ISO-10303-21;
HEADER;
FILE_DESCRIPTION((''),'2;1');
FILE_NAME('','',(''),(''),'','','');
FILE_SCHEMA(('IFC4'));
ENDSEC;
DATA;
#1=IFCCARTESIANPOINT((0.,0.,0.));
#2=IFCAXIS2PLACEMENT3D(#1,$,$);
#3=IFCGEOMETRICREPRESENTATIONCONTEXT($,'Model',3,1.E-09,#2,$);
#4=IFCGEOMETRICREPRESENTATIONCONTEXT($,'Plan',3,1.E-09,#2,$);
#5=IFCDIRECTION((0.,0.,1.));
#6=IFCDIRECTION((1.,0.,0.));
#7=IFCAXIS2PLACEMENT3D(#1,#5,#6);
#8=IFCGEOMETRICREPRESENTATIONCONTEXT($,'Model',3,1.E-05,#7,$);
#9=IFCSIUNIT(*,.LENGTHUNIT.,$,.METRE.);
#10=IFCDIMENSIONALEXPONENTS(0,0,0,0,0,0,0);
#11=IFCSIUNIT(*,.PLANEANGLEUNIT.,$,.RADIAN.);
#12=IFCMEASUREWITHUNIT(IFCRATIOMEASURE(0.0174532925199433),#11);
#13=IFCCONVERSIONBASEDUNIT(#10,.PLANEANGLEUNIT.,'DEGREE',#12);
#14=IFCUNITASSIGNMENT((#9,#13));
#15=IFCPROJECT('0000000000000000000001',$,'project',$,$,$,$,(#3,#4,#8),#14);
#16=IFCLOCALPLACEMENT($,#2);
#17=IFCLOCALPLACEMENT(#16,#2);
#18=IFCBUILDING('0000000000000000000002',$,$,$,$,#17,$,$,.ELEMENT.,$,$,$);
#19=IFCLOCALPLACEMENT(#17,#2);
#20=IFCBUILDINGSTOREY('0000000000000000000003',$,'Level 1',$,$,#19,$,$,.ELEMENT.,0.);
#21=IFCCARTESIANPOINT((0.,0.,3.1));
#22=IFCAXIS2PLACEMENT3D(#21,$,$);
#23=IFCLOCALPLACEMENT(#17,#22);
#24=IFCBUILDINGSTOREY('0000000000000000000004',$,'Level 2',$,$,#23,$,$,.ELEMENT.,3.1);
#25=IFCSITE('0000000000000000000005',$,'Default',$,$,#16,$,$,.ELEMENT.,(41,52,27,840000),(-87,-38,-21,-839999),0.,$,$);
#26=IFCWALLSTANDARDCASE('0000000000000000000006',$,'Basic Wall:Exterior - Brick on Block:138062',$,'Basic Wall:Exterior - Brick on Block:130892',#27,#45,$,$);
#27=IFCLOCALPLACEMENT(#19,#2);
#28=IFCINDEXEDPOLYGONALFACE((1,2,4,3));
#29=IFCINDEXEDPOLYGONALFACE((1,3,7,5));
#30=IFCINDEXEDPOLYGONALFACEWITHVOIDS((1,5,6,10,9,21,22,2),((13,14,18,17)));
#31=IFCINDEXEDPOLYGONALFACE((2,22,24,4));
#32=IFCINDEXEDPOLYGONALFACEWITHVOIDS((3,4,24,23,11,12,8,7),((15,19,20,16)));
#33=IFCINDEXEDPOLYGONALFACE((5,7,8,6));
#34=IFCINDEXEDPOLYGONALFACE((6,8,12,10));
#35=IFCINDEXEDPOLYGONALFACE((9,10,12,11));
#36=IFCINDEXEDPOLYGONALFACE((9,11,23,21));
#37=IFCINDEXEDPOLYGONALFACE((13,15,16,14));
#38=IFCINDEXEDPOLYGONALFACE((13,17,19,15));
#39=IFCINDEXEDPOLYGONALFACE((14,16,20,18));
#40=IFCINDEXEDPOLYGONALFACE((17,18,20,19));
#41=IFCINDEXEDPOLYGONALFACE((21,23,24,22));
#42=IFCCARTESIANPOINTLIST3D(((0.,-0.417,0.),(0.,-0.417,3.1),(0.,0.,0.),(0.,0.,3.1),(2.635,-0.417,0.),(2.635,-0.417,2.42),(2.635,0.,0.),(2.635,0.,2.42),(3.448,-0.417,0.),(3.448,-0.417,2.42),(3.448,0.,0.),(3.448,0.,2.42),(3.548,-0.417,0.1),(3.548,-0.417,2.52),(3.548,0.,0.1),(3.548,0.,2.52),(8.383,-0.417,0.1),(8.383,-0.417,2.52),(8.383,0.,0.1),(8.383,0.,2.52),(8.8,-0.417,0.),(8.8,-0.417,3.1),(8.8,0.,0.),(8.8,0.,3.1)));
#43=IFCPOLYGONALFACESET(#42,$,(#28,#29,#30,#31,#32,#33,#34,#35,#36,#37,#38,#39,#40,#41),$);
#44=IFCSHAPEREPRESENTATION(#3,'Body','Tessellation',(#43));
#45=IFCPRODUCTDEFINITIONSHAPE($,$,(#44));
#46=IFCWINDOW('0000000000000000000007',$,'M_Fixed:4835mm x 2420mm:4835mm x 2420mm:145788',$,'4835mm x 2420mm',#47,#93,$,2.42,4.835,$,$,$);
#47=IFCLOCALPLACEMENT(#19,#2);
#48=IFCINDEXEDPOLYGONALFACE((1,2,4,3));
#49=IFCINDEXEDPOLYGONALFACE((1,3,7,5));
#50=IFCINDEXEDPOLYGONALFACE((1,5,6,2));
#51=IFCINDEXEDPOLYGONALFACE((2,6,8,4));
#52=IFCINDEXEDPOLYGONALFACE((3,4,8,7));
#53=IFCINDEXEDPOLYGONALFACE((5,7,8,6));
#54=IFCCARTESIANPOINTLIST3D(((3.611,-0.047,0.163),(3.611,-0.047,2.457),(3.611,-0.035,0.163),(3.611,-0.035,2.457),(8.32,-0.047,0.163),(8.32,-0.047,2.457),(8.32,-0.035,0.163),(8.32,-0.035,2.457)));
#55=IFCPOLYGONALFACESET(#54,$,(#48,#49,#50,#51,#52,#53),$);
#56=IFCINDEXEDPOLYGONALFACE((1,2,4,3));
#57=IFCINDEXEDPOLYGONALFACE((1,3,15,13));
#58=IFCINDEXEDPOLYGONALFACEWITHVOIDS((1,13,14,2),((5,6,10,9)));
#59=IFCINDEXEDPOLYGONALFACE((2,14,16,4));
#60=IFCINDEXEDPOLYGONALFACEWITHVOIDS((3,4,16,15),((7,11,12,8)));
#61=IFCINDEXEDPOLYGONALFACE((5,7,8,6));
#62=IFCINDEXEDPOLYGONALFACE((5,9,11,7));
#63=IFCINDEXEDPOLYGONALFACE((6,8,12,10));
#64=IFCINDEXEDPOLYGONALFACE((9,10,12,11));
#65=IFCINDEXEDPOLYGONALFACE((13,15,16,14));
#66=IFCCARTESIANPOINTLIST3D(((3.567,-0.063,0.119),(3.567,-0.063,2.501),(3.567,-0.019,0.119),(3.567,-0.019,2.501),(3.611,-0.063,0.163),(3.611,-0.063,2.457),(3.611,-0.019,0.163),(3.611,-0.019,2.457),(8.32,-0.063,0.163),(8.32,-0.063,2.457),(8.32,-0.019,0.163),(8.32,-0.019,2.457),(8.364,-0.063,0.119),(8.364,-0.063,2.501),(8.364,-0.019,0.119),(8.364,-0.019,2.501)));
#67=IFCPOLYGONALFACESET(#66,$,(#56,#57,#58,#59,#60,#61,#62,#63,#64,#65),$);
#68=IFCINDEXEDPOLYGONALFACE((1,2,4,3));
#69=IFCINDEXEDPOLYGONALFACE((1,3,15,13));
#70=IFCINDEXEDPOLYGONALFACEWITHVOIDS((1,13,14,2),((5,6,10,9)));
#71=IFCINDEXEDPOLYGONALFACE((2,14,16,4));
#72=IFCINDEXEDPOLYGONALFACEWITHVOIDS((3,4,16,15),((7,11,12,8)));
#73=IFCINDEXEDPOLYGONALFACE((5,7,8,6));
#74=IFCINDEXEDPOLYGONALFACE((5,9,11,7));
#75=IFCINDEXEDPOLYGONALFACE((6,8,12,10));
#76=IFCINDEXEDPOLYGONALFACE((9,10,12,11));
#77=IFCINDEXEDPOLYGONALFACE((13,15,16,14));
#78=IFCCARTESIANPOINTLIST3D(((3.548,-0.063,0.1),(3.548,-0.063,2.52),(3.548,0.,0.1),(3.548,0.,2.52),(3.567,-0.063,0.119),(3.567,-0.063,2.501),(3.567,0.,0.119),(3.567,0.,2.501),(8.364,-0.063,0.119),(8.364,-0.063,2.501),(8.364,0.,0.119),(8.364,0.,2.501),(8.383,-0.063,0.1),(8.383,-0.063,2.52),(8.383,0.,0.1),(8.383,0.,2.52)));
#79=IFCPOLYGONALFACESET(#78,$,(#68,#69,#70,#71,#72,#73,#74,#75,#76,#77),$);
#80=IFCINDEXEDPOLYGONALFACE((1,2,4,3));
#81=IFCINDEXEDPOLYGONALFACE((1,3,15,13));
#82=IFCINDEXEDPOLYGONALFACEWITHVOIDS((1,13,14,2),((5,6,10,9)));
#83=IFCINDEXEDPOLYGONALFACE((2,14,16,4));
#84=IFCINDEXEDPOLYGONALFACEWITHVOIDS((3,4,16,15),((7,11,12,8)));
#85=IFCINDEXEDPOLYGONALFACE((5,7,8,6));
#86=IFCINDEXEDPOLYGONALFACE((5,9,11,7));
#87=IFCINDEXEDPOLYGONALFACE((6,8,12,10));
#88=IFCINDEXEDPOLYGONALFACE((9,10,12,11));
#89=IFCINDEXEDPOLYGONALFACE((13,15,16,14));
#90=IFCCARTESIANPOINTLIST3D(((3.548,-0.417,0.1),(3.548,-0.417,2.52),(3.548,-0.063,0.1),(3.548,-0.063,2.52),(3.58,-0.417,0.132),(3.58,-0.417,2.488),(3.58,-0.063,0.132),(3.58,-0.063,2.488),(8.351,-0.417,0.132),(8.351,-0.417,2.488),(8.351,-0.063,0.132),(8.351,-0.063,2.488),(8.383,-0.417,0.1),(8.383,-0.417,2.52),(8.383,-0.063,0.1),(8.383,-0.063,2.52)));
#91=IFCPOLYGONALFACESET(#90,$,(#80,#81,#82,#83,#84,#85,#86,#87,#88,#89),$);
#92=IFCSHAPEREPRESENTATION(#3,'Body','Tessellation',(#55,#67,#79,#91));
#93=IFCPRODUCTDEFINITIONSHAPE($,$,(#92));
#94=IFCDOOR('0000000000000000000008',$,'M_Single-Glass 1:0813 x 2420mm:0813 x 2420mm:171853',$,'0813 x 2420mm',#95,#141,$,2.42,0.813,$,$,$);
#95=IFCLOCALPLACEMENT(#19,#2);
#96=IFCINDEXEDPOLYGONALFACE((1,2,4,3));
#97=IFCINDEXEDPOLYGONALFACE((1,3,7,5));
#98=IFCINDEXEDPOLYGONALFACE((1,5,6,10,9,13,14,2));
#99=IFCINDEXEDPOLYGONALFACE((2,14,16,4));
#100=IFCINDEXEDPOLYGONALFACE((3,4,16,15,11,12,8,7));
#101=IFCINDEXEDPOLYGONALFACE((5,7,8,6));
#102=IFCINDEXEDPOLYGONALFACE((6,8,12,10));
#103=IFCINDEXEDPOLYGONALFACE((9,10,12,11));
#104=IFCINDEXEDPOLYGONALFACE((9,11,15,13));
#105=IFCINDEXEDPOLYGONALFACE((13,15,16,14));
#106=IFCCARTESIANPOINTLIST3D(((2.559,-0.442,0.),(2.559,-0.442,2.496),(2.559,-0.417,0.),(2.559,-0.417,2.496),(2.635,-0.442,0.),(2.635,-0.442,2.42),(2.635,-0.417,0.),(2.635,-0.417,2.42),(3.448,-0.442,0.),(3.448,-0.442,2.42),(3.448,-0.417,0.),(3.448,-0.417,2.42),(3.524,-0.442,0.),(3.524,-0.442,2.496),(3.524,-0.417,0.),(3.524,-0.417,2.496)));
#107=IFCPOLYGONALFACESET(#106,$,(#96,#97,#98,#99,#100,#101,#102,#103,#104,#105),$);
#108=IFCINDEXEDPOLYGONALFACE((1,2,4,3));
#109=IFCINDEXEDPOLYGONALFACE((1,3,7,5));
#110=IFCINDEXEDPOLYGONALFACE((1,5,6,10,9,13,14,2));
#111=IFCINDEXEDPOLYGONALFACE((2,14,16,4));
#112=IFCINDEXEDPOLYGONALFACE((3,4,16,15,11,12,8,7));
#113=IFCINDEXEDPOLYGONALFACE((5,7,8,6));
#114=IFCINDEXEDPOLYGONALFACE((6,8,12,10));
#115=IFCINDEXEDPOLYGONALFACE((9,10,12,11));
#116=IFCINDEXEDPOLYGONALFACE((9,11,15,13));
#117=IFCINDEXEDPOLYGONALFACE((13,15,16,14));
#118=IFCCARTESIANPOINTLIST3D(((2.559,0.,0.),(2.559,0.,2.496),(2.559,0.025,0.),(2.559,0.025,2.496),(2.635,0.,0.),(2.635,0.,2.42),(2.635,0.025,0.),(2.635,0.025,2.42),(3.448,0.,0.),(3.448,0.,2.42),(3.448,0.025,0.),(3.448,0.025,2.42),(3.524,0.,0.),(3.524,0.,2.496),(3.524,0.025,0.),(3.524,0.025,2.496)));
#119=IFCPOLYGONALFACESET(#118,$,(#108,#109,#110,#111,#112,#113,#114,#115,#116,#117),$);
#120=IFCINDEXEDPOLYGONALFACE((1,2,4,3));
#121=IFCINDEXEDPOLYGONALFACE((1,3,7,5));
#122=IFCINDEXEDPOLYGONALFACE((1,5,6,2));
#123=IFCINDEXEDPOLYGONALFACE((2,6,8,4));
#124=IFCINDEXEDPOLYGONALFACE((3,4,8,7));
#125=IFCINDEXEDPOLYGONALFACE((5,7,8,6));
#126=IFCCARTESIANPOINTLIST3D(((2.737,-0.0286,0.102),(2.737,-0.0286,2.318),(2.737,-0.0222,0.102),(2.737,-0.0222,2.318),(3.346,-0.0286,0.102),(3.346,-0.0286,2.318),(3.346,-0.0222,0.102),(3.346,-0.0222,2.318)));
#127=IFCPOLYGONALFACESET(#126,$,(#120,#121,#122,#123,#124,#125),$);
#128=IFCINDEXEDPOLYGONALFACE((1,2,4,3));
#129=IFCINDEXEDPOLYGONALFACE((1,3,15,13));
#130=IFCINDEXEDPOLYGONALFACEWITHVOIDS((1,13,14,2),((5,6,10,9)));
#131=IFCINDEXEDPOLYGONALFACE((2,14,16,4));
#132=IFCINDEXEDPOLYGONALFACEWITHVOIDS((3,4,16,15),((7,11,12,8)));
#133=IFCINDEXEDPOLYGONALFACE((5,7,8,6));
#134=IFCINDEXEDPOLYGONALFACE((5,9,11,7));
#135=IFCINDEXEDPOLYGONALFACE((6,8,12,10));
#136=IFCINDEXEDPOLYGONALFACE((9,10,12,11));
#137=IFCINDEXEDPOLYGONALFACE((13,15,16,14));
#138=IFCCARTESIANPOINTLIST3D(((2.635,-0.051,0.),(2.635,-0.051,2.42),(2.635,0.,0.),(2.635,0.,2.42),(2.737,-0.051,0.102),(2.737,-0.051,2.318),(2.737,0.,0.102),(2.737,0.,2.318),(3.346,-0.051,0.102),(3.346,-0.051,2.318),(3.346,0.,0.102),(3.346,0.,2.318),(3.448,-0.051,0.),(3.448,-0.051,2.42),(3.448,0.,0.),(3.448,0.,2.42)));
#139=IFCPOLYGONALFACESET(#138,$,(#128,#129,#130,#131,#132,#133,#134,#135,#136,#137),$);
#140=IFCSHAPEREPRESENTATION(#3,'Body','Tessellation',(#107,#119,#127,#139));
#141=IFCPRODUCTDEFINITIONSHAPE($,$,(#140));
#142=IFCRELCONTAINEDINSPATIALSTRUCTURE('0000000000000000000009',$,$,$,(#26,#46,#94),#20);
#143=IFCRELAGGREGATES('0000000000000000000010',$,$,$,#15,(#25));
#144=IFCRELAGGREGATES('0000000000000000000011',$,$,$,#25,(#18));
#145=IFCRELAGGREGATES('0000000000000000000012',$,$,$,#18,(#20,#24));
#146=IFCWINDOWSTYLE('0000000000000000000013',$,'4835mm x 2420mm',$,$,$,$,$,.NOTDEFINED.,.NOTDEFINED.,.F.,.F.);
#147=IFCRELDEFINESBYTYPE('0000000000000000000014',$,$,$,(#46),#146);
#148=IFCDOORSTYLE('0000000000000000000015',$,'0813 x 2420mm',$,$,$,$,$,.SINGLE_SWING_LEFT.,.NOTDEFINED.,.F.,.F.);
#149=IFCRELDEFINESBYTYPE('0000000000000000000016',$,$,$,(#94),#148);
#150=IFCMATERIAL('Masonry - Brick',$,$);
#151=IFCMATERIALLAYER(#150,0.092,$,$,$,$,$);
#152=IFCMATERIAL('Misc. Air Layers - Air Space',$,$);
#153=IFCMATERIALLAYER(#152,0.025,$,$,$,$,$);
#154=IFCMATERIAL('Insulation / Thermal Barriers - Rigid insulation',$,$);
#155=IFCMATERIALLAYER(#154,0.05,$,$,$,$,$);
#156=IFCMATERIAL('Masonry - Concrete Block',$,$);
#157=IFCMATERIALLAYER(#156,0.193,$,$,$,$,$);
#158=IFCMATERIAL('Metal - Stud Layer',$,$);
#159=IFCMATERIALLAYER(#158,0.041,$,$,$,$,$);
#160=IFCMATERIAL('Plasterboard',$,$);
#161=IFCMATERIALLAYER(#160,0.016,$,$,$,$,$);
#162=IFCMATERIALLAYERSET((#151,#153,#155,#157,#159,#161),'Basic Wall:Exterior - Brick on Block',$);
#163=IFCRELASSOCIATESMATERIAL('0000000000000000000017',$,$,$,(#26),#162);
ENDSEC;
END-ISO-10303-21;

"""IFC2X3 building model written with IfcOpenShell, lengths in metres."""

from ifc_helpers import new_model, entity, si_unit, converted_unit, frame, frame_2d, origin, origin_with_axes, origin_2d_with_axis, place, context, project, spatial, polyline, rectangle, outline, extrude, source, transform, mapped, material, layer, layer_set, layer_usage, type_object, type_shapes, element, fill, save


model = new_model("IFC2X3")

# Units and contexts
model_context_1 = context("Model", 3, precision=1e-09, world=origin())
plan_context = context("Plan", 3, precision=1e-09, world=origin())
model_context_2 = context("Model", 3, precision=1e-05, world=origin_with_axes())
ifc_project = project(units=[si_unit("LENGTHUNIT", "METRE"), converted_unit("PLANEANGLEUNIT", "DEGREE", entity("IfcRatioMeasure", 0.0174532925199433), si_unit("PLANEANGLEUNIT", "RADIAN"), dimensions=[0, 0, 0, 0, 0, 0, 0])], contexts=[model_context_1, plan_context, model_context_2])

# Site, building, storey
site_placement = place(None, origin())
site = spatial("IfcSite", under=ifc_project, at=site_placement, Name="Default", CompositionType="ELEMENT", RefLatitude=(41, 52, 27, 840000), RefLongitude=(-87, -38, -21, -839999), RefElevation=0.0)
building_placement = place(site_placement, origin())
building = spatial("IfcBuilding", under=site, at=building_placement, CompositionType="ELEMENT")
storey_1_placement = place(building_placement, origin())
storey_1 = spatial("IfcBuildingStorey", under=building, at=storey_1_placement, Name="Level 1", CompositionType="ELEMENT", Elevation=0.0)

# Wall, openings, window, door
ifc_material_1 = material(Name="Masonry - Brick")
ifc_layer_1 = layer(ifc_material_1, 0.092)
ifc_material_2 = material(Name="Misc. Air Layers - Air Space")
ifc_layer_2 = layer(ifc_material_2, 0.025)
ifc_material_3 = material(Name="Insulation / Thermal Barriers - Rigid insulation")
ifc_layer_3 = layer(ifc_material_3, 0.05)
ifc_material_4 = material(Name="Masonry - Concrete Block")
ifc_layer_4 = layer(ifc_material_4, 0.193)
ifc_material_5 = material(Name="Metal - Stud Layer")
ifc_layer_5 = layer(ifc_material_5, 0.041)
ifc_material_6 = material(Name="Plasterboard")
ifc_layer_6 = layer(ifc_material_6, 0.016)
ifc_layer_set_1 = layer_set([ifc_layer_1, ifc_layer_2, ifc_layer_3, ifc_layer_4, ifc_layer_5, ifc_layer_6], Name="Basic Wall:Exterior - Brick on Block")
ifc_layer_usage_1 = layer_usage(ifc_layer_set_1, "AXIS2", "NEGATIVE", 0.2085)
wall_1_placement = place(storey_1_placement, frame((0.0, -0.2085, 0.0)))
wall_1 = element("IfcWallStandardCase", 1, at=wall_1_placement, inside=storey_1, material=ifc_layer_usage_1, Name="Basic Wall:Exterior - Brick on Block:138062", ObjectType="Basic Wall:Exterior - Brick on Block:130892", context=model_context_1, shape_type="SweptSolid", body=[
    extrude(rectangle(XDim=8.8, YDim=0.417, at=frame_2d((4.4, 0.0), x_axis=(-1.0, 0.0))), origin(), (0.0, 0.0, 1.0), 3.1),
])
opening_1_placement = place(wall_1_placement, frame((3.548, -0.2085, 0.1)))
opening_1 = element("IfcOpeningElement", 2, at=opening_1_placement, cuts=wall_1, ObjectType="Opening", context=model_context_1, shape_type="SweptSolid", body=[
    extrude(rectangle(XDim=2.42, YDim=4.835, at=frame_2d((1.21, 2.4175), x_axis=(1.0, 0.0))), frame((0.0, 0.0, 0.0), z_axis=(0.0, 1.0, 0.0), x_axis=(0.0, 0.0, 1.0)), (0.0, 0.0, 1.0), 0.417),
])
opening_2_placement = place(wall_1_placement, frame((2.635, -0.2085, 0.0)))
opening_2 = element("IfcOpeningElement", 3, at=opening_2_placement, cuts=wall_1, ObjectType="Opening", context=model_context_1, shape_type="SweptSolid", body=[
    extrude(rectangle(XDim=0.813, YDim=2.42, at=frame_2d((1.21, 0.4065), x_axis=(0.0, -1.0))), frame((0.0, 0.0, 0.0), z_axis=(0.0, 1.0, 0.0), x_axis=(0.0, 0.0, 1.0)), (0.0, 0.0, 1.0), 0.417),
])
window_style_1 = type_object("IfcWindowStyle", Name="4835mm x 2420mm", ConstructionType="NOTDEFINED", OperationType="NOTDEFINED", ParameterTakesPrecedence=False, Sizeable=False)
shared_shape_1 = source(origin(), model_context_1, "Body", "SweptSolid", [
    extrude(rectangle(XDim=0.012, YDim=4.709, at=origin_2d_with_axis()), frame((2.4175, 0.376, 0.063), z_axis=(0.0, 0.0, 1.0), x_axis=(0.0, -1.0, 0.0)), (0.0, 0.0, 1.0), 2.294),
    extrude(outline(polyline([(-2.3985, -1.191), (2.3985, -1.191), (2.3985, 1.191), (-2.3985, 1.191), (-2.3985, -1.191)]), holes=[polyline([(-2.3545, -1.147), (-2.3545, 1.147), (2.3545, 1.147), (2.3545, -1.147), (-2.3545, -1.147)])]), frame((2.4175, 0.354, 1.21), z_axis=(0.0, 1.0, 0.0), x_axis=(1.0, 0.0, 0.0)), (0.0, 0.0, 1.0), 0.044),
    extrude(outline(polyline([(-2.4175, -1.21), (2.4175, -1.21), (2.4175, 1.21), (-2.4175, 1.21), (-2.4175, -1.21)]), holes=[polyline([(-2.3985, -1.191), (-2.3985, 1.191), (2.3985, 1.191), (2.3985, -1.191), (-2.3985, -1.191)])]), frame((2.4175, 0.354, 1.21), z_axis=(0.0, 1.0, 0.0), x_axis=(1.0, 0.0, 0.0)), (0.0, 0.0, 1.0), 0.063),
    extrude(outline(polyline([(-2.4175, -1.21), (2.4175, -1.21), (2.4175, 1.21), (-2.4175, 1.21), (-2.4175, -1.21)]), holes=[polyline([(-2.3855, -1.178), (-2.3855, 1.178), (2.3855, 1.178), (2.3855, -1.178), (-2.3855, -1.178)])]), frame((2.4175, 0.0, 1.21), z_axis=(0.0, 1.0, 0.0), x_axis=(1.0, 0.0, 0.0)), (0.0, 0.0, 1.0), 0.354),
])
type_shapes(window_style_1, [shared_shape_1])
window_1_placement = place(opening_1_placement, origin())
window_1 = element("IfcWindow", 4, at=window_1_placement, inside=storey_1, type_object=window_style_1, Name="M_Fixed:4835mm x 2420mm:4835mm x 2420mm:145788", ObjectType="4835mm x 2420mm", OverallHeight=2.42, OverallWidth=4.835, context=model_context_1, shape_type="MappedRepresentation", body=[
    mapped(shared_shape_1, transform((0.0, 0.0, 0.0), scale=1.0)),
])
fill(opening_1, window_1)
door_style_1 = type_object("IfcDoorStyle", Name="0813 x 2420mm", ConstructionType="NOTDEFINED", OperationType="SINGLE_SWING_LEFT", ParameterTakesPrecedence=False, Sizeable=False)
shared_shape_2 = source(origin(), model_context_1, "Body", "SweptSolid", [
    extrude(outline(polyline([(-0.4065, -1.191), (-0.4065, 1.229), (-0.4825, 1.229), (-0.4825, -1.267), (0.4825, -1.267), (0.4825, 1.229), (0.4065, 1.229), (0.4065, -1.191), (-0.4065, -1.191)])), frame((0.4065, 0.0, 1.229), z_axis=(0.0, 1.0, 0.0), x_axis=(1.0, 0.0, 0.0)), (0.0, 0.0, -1.0), 0.025),
    extrude(outline(polyline([(-0.4065, -1.191), (-0.4065, 1.229), (-0.4825, 1.229), (-0.4825, -1.267), (0.4825, -1.267), (0.4825, 1.229), (0.4065, 1.229), (0.4065, -1.191), (-0.4065, -1.191)])), frame((0.4065, 0.442, 1.229), z_axis=(0.0, 1.0, 0.0), x_axis=(1.0, 0.0, 0.0)), (0.0, 0.0, -1.0), 0.025),
    extrude(rectangle(XDim=0.609, YDim=0.0064, at=origin_2d_with_axis()), frame((0.4065, 0.3916, 0.102)), (0.0, 0.0, 1.0), 2.216),
    extrude(outline(polyline([(-1.21, -0.4065), (1.21, -0.4065), (1.21, 0.4065), (-1.21, 0.4065), (-1.21, -0.4065)]), holes=[polyline([(-1.108, 0.3045), (1.108, 0.3045), (1.108, -0.3045), (-1.108, -0.3045), (-1.108, 0.3045)])]), frame((0.4065, 0.417, 1.21), z_axis=(0.0, -1.0, 0.0), x_axis=(0.0, 0.0, -1.0)), (0.0, 0.0, 1.0), 0.051),
])
type_shapes(door_style_1, [shared_shape_2])
door_1_placement = place(opening_2_placement, origin())
door_1 = element("IfcDoor", 5, at=door_1_placement, inside=storey_1, type_object=door_style_1, Name="M_Single-Glass 1:0813 x 2420mm:0813 x 2420mm:171853", ObjectType="0813 x 2420mm", OverallHeight=2.42, OverallWidth=0.813, context=model_context_1, shape_type="MappedRepresentation", body=[
    mapped(shared_shape_2, transform((0.0, 0.0, 0.0), scale=1.0)),
])
fill(opening_2, door_1)

# Shared definitions
storey_2_placement = place(building_placement, frame((0.0, 0.0, 3.1)))
storey_2 = spatial("IfcBuildingStorey", under=building, at=storey_2_placement, Name="Level 2", CompositionType="ELEMENT", Elevation=3.1)

save(model, "model.ifc")
